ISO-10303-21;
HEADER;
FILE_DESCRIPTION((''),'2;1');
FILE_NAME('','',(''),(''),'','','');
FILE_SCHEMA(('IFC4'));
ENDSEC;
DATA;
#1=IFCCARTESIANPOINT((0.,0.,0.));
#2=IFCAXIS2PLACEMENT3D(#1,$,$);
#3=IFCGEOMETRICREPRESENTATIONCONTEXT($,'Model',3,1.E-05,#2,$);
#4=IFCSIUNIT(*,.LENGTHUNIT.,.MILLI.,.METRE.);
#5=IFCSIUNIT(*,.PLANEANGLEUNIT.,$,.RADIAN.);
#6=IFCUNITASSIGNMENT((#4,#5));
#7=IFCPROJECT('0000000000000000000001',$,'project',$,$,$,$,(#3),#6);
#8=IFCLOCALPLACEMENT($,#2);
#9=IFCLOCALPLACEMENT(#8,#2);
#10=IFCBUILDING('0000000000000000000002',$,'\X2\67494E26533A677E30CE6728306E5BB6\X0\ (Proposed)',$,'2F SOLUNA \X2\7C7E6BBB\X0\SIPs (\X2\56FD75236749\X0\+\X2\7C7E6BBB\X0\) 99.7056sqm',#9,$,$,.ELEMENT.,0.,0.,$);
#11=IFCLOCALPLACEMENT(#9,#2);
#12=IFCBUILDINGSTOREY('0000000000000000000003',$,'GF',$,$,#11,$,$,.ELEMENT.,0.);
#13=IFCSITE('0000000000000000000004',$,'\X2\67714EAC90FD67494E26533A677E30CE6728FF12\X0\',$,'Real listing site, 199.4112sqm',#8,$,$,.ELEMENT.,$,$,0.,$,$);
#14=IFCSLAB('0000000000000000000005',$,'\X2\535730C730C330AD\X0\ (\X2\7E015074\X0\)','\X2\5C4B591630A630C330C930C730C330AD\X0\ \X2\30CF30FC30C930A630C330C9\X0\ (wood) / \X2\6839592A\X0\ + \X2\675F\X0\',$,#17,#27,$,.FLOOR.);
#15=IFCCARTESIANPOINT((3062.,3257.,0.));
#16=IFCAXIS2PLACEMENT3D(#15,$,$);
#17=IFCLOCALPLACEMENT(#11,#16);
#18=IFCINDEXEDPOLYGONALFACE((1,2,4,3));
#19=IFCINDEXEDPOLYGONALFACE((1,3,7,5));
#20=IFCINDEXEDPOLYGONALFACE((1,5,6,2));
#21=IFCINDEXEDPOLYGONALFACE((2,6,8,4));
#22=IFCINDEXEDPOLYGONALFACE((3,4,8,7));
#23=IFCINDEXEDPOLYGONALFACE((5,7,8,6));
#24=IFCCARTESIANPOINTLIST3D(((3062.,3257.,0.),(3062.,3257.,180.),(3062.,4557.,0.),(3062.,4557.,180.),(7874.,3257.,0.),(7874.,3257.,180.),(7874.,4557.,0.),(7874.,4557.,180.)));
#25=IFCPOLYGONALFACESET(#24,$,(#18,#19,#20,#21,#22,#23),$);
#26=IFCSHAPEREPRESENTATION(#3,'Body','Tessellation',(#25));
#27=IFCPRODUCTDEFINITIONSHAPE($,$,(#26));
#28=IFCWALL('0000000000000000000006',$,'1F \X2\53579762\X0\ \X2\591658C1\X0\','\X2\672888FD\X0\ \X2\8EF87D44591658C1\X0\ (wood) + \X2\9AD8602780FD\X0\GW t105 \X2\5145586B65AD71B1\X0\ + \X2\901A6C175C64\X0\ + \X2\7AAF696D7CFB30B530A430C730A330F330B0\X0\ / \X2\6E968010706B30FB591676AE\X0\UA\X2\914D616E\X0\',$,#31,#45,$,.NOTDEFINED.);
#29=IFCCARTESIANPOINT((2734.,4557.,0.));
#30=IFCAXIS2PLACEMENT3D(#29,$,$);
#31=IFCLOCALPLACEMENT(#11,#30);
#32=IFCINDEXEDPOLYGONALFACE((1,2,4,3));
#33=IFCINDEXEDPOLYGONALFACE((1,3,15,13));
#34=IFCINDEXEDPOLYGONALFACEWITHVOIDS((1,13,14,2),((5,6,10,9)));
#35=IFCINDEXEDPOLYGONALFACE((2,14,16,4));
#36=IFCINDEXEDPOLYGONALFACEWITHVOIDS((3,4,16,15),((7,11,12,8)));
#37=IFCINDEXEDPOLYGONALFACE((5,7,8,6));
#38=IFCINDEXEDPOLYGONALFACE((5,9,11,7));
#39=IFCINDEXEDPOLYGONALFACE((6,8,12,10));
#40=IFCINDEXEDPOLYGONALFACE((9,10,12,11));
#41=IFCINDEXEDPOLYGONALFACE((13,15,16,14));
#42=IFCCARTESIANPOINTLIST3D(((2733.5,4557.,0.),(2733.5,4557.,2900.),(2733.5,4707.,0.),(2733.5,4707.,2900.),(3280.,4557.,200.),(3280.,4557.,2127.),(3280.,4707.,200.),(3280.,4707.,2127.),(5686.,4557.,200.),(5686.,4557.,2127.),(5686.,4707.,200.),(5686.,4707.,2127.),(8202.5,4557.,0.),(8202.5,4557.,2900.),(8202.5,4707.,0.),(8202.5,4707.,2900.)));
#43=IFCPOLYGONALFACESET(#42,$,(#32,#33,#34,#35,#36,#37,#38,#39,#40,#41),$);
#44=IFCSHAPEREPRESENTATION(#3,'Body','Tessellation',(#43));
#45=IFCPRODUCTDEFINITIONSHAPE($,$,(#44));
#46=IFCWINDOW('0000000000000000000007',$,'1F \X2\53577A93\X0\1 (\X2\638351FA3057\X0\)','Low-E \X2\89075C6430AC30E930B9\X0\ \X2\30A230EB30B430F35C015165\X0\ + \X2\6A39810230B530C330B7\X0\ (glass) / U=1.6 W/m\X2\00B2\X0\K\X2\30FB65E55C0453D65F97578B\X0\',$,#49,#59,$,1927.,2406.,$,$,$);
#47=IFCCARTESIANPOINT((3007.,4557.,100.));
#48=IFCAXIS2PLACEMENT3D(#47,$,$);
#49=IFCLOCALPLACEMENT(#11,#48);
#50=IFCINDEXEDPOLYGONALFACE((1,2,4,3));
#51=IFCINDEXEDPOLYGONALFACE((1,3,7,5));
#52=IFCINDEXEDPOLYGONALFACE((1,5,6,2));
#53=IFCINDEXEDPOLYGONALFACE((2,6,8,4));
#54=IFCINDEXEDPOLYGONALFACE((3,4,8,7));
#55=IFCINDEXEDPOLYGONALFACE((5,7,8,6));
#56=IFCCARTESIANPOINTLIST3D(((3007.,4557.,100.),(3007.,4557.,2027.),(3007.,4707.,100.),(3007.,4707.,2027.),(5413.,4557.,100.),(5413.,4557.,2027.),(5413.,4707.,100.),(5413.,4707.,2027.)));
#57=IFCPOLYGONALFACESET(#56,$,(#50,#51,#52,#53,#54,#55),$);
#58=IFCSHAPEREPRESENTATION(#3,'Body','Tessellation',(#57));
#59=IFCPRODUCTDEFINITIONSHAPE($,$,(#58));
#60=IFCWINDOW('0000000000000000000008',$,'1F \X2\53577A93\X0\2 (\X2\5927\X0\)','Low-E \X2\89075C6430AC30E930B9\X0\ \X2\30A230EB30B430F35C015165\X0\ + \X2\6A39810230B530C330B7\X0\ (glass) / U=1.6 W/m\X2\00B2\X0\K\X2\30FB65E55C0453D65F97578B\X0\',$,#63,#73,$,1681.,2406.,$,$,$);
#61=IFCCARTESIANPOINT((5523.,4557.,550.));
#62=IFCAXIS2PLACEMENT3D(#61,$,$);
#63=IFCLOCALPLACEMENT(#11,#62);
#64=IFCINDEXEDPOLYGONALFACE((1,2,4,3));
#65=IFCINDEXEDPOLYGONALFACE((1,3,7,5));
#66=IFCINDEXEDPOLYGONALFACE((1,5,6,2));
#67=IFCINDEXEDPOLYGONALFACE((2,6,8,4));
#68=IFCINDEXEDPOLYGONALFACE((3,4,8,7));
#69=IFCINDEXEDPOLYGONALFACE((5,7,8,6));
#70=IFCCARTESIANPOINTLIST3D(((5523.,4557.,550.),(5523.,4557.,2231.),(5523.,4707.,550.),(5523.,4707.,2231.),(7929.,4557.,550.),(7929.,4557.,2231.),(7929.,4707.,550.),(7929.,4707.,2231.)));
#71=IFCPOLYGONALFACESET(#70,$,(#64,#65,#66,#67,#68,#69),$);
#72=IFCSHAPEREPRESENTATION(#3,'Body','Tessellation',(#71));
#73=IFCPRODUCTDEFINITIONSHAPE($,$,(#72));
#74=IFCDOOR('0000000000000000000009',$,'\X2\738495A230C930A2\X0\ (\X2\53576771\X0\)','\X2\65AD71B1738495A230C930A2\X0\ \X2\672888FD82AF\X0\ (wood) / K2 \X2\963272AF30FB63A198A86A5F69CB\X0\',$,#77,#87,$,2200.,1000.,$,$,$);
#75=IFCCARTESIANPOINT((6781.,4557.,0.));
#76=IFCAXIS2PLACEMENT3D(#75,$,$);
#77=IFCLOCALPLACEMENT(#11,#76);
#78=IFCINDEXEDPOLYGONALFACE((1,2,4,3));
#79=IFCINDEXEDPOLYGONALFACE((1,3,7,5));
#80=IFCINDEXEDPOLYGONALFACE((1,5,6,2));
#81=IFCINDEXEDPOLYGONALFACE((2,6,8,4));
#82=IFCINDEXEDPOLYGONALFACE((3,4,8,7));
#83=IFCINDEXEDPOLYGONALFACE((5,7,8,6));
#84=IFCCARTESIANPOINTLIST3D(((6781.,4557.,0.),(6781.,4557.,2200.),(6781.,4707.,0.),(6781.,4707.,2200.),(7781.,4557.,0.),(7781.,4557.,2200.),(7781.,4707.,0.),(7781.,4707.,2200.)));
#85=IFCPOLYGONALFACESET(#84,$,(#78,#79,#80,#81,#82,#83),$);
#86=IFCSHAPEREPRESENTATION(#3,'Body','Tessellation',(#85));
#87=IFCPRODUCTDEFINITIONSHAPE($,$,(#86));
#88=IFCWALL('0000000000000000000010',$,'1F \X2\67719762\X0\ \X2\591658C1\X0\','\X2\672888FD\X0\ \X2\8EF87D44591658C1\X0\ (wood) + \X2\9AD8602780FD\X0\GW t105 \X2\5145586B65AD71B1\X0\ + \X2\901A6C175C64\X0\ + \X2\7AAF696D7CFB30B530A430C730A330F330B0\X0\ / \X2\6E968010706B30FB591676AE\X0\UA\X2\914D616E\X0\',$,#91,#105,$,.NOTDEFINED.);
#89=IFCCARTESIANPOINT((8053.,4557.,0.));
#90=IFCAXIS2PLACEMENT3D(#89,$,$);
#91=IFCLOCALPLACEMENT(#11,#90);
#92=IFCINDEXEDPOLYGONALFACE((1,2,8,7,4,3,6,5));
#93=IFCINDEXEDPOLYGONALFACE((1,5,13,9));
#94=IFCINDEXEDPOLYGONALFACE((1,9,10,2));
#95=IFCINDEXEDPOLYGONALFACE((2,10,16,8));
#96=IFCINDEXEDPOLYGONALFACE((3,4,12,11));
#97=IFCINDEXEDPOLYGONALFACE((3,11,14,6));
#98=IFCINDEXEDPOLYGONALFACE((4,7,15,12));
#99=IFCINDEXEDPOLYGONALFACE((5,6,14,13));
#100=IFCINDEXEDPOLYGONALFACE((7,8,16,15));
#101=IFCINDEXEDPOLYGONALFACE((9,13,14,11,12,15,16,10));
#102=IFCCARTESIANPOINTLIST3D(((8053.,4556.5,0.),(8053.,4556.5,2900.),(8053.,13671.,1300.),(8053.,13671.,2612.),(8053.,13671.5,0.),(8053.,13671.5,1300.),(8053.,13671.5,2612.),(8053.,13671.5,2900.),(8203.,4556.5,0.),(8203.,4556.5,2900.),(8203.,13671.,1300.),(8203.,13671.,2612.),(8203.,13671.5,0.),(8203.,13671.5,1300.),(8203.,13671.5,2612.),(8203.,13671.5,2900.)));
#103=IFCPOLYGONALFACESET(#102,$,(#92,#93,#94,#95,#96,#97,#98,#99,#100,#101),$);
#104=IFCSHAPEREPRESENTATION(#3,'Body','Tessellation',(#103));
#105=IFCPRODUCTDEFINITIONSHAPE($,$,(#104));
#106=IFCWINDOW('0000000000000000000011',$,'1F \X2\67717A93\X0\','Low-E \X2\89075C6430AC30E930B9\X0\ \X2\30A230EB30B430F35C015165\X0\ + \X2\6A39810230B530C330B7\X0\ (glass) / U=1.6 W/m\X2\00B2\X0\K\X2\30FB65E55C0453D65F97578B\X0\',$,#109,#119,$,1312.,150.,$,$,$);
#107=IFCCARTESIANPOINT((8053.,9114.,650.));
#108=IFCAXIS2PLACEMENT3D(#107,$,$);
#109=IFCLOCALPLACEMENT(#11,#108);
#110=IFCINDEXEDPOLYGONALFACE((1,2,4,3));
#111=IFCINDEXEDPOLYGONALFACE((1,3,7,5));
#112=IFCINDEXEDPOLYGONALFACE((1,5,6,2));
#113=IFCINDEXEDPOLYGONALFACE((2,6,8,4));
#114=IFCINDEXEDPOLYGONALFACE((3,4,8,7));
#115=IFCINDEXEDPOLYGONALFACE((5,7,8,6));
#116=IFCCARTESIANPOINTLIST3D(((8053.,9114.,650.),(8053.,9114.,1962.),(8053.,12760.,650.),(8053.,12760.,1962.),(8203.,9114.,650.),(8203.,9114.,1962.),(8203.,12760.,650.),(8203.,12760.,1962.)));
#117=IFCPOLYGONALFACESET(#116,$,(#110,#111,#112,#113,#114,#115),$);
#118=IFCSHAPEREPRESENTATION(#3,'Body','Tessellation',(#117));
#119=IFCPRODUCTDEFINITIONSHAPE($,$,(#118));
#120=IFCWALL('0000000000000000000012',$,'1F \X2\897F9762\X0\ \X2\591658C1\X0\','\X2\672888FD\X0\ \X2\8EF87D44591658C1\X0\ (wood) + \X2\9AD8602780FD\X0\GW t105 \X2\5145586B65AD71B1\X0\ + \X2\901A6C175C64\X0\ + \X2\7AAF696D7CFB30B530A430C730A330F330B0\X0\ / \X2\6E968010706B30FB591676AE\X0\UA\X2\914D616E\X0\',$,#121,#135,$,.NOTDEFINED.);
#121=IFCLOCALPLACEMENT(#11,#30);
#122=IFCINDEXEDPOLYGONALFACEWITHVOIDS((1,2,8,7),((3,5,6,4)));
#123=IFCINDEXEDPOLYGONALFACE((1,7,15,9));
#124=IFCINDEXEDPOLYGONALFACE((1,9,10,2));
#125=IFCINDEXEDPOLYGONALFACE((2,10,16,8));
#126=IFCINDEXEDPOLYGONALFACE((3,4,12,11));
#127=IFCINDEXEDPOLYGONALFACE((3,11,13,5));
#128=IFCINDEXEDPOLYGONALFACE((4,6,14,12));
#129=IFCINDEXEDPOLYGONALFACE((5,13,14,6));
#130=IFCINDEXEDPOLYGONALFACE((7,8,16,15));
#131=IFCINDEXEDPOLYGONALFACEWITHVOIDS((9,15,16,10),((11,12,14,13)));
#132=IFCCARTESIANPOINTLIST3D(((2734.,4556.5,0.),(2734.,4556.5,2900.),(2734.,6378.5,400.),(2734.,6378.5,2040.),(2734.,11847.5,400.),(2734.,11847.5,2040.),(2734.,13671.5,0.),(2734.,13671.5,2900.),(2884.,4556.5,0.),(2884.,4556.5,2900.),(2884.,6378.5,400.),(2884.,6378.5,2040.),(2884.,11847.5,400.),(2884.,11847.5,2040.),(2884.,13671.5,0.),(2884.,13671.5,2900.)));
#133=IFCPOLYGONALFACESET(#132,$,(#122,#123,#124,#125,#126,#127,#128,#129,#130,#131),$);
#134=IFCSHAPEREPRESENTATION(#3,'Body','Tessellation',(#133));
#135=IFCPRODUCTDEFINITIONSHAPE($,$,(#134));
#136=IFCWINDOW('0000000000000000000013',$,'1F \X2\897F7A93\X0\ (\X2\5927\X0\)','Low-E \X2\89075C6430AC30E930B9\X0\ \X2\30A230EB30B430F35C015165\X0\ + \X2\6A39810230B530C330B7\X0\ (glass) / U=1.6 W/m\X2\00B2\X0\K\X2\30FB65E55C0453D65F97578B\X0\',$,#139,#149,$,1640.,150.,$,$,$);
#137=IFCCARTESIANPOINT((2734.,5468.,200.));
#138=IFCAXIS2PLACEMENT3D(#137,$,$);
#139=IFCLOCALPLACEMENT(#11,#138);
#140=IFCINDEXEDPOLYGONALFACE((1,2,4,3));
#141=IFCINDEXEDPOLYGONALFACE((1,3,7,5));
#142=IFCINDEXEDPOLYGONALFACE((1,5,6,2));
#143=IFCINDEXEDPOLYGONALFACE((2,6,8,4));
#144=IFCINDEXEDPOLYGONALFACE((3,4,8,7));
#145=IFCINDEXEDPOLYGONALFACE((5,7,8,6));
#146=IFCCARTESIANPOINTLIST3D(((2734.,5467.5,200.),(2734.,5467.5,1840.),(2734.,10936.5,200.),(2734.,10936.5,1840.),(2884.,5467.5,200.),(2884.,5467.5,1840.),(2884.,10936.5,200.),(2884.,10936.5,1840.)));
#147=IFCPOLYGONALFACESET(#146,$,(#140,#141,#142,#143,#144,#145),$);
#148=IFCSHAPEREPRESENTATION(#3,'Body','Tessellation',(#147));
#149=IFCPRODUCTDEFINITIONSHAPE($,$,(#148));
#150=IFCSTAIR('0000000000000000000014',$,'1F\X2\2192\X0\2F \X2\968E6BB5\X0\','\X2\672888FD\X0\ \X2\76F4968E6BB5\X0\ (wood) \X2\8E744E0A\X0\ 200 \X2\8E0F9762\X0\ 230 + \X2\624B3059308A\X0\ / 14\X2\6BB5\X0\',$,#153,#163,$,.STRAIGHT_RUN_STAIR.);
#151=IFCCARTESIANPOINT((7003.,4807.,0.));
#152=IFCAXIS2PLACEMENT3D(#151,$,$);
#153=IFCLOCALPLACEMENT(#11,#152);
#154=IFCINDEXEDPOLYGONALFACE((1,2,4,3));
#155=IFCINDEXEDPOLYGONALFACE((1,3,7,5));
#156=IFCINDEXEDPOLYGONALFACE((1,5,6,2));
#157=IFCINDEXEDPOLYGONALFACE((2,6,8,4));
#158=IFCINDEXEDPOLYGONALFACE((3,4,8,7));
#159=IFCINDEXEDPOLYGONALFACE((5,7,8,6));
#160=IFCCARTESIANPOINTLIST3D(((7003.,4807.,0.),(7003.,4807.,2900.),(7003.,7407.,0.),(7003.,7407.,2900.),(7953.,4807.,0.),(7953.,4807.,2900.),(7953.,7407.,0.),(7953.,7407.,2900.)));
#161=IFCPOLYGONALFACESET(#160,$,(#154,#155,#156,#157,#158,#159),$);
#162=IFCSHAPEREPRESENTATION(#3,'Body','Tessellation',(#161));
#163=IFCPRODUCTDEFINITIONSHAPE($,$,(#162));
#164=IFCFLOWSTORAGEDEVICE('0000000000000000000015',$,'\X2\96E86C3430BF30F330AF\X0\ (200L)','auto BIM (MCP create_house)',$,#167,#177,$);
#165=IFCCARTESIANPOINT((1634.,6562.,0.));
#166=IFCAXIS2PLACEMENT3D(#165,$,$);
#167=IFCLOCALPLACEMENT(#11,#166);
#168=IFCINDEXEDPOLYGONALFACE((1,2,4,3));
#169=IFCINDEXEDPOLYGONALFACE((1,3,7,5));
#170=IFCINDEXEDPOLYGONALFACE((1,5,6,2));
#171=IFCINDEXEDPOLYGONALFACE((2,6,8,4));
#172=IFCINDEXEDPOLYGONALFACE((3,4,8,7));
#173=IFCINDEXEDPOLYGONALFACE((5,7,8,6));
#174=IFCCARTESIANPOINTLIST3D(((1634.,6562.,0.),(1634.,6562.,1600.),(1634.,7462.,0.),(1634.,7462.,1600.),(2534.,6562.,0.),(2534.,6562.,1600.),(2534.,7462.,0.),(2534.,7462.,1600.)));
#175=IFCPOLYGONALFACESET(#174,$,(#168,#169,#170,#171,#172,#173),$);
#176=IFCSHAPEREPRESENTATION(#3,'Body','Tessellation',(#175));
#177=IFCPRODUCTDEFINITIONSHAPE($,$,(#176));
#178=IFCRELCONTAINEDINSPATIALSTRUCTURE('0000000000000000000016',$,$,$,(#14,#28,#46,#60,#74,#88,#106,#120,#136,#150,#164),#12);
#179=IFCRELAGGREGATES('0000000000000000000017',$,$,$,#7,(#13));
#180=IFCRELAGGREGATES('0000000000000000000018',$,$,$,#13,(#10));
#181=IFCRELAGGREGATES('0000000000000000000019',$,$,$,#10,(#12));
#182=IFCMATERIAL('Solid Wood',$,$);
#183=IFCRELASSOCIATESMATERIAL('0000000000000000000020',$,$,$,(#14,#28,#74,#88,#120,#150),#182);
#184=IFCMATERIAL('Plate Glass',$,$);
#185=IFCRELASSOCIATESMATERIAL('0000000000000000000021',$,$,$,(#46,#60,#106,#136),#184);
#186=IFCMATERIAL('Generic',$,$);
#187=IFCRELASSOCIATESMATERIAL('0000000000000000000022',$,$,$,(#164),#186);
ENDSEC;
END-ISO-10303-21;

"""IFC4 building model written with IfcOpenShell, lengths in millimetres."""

from ifc_helpers import new_model, si_unit, frame, frame_2d, origin, place, context, project, spatial, rectangle, extrude, material, element, fill, save


model = new_model("IFC4")

# Units and contexts
model_context = context("Model", 3, precision=1e-05, world=origin())
ifc_project = project(units=[si_unit("LENGTHUNIT", "METRE", prefix="MILLI"), si_unit("PLANEANGLEUNIT", "RADIAN")], contexts=[model_context])

# Site, building, storey
site_placement = place(None, origin())
site = spatial("IfcSite", under=ifc_project, at=site_placement, Name="東京都杉並区松ノ木２", ObjectType="Real listing site, 199.4112sqm", CompositionType="ELEMENT", RefElevation=0.0)
building_placement = place(site_placement, origin())
building = spatial("IfcBuilding", under=site, at=building_placement, Name="杉並区松ノ木の家 (Proposed)", ObjectType="2F SOLUNA 籾殻SIPs (国産杉+籾殻) 99.7056sqm", CompositionType="ELEMENT", ElevationOfRefHeight=0.0, ElevationOfTerrain=0.0)
storey_placement = place(building_placement, origin())
storey = spatial("IfcBuildingStorey", under=building, at=storey_placement, Name="GF", CompositionType="ELEMENT", Elevation=0.0)

# Slab
ifc_material_1 = material(Name="Solid Wood")
slab_1_placement = place(storey_placement, frame((3062.0, 3257.0, 0.0)))
element("IfcSlab", 1, at=slab_1_placement, inside=storey, material=ifc_material_1, Name="南デッキ (縁側)", Description="屋外ウッドデッキ ハードウッド (wood) / 根太 + 束", PredefinedType="FLOOR", context=model_context, shape_type="SweptSolid", body=[
    extrude(rectangle(XDim=4812.0, YDim=1300.0, at=frame_2d((2406.0, 650.0))), frame((3062.0, 3257.0, 0.0)), (0.0, 0.0, 1.0), 180.0),
])

# Wall, openings, windows, door
wall_1_placement = place(storey_placement, frame((2734.0, 4557.0, 0.0)))
wall_1 = element("IfcWall", 2, at=wall_1_placement, inside=storey, material=ifc_material_1, Name="1F 南面 外壁", Description="木製 軸組外壁 (wood) + 高性能GW t105 充填断熱 + 通気層 + 窯業系サイディング / 準耐火・外皮UA配慮", PredefinedType="NOTDEFINED", context=model_context, shape_type="SweptSolid", body=[
    extrude(rectangle(XDim=5469.0, YDim=150.0, at=frame_2d((2734.0, 75.0))), frame((2734.0, 4557.0, 0.0)), (0.0, 0.0, 1.0), 2900.0),
])
opening_1_placement = place(storey_placement, frame((3007.0, 4557.0, 100.0)))
opening_1 = element("IfcOpeningElement", 3, at=opening_1_placement, cuts=wall_1, PredefinedType="NOTDEFINED", context=model_context, shape_type="SweptSolid", body=[
    extrude(rectangle(XDim=2406.0, YDim=150.0, at=frame_2d((1203.0, 75.0))), frame((3007.0, 4557.0, 100.0)), (0.0, 0.0, 1.0), 1927.0),
])
opening_2_placement = place(storey_placement, frame((5523.0, 4557.0, 550.0)))
opening_2 = element("IfcOpeningElement", 4, at=opening_2_placement, cuts=wall_1, PredefinedType="NOTDEFINED", context=model_context, shape_type="SweptSolid", body=[
    extrude(rectangle(XDim=2406.0, YDim=150.0, at=frame_2d((1203.0, 75.0))), frame((5523.0, 4557.0, 550.0)), (0.0, 0.0, 1.0), 1681.0),
])
opening_3_placement = place(storey_placement, frame((6781.0, 4557.0, 0.0)))
opening_3 = element("IfcOpeningElement", 5, at=opening_3_placement, cuts=wall_1, PredefinedType="NOTDEFINED", context=model_context, shape_type="SweptSolid", body=[
    extrude(rectangle(XDim=1000.0, YDim=150.0, at=frame_2d((500.0, 75.0))), frame((6781.0, 4557.0, 0.0)), (0.0, 0.0, 1.0), 2200.0),
])
ifc_material_2 = material(Name="Plate Glass")
window_1_placement = place(storey_placement, frame((3007.0, 4557.0, 100.0)))
window_1 = element("IfcWindow", 6, at=window_1_placement, inside=storey, material=ifc_material_2, Name="1F 南窓1 (掃出し)", Description="Low-E 複層ガラス アルゴン封入 + 樹脂サッシ (glass) / U=1.6 W/m²K・日射取得型", OverallHeight=1927.0, OverallWidth=2406.0, context=model_context, shape_type="SweptSolid", body=[
    extrude(rectangle(XDim=2406.0, YDim=150.0, at=frame_2d((1203.0, 75.0))), frame((3007.0, 4557.0, 100.0)), (0.0, 0.0, 1.0), 1927.0),
])
fill(opening_1, window_1)
window_2_placement = place(storey_placement, frame((5523.0, 4557.0, 550.0)))
window_2 = element("IfcWindow", 7, at=window_2_placement, inside=storey, material=ifc_material_2, Name="1F 南窓2 (大)", Description="Low-E 複層ガラス アルゴン封入 + 樹脂サッシ (glass) / U=1.6 W/m²K・日射取得型", OverallHeight=1681.0, OverallWidth=2406.0, context=model_context, shape_type="SweptSolid", body=[
    extrude(rectangle(XDim=2406.0, YDim=150.0, at=frame_2d((1203.0, 75.0))), frame((5523.0, 4557.0, 550.0)), (0.0, 0.0, 1.0), 1681.0),
])
fill(opening_2, window_2)
door_placement = place(storey_placement, frame((6781.0, 4557.0, 0.0)))
door = element("IfcDoor", 8, at=door_placement, inside=storey, material=ifc_material_1, Name="玄関ドア (南東)", Description="断熱玄関ドア 木製芯 (wood) / K2 防犯・採風機構", OverallHeight=2200.0, OverallWidth=1000.0, context=model_context, shape_type="SweptSolid", body=[
    extrude(rectangle(XDim=1000.0, YDim=150.0, at=frame_2d((500.0, 75.0))), frame((6781.0, 4557.0, 0.0)), (0.0, 0.0, 1.0), 2200.0),
])
fill(opening_3, door)

# Walls, openings, windows
wall_2_placement = place(storey_placement, frame((8053.0, 4557.0, 0.0)))
wall_2 = element("IfcWall", 9, at=wall_2_placement, inside=storey, material=ifc_material_1, Name="1F 東面 外壁", Description="木製 軸組外壁 (wood) + 高性能GW t105 充填断熱 + 通気層 + 窯業系サイディング / 準耐火・外皮UA配慮", PredefinedType="NOTDEFINED", context=model_context, shape_type="SweptSolid", body=[
    extrude(rectangle(XDim=150.0, YDim=9115.0, at=frame_2d((75.0, 4557.0))), frame((8053.0, 4557.0, 0.0)), (0.0, 0.0, 1.0), 2900.0),
])
opening_4_placement = place(storey_placement, frame((8053.0, 9114.0, 650.0)))
opening_4 = element("IfcOpeningElement", 10, at=opening_4_placement, cuts=wall_2, PredefinedType="NOTDEFINED", context=model_context, shape_type="SweptSolid", body=[
    extrude(rectangle(XDim=150.0, YDim=3646.0, at=frame_2d((75.0, 1823.0))), frame((8053.0, 9114.0, 650.0)), (0.0, 0.0, 1.0), 1312.0),
])
window_3_placement = place(storey_placement, frame((8053.0, 9114.0, 650.0)))
window_3 = element("IfcWindow", 11, at=window_3_placement, inside=storey, material=ifc_material_2, Name="1F 東窓", Description="Low-E 複層ガラス アルゴン封入 + 樹脂サッシ (glass) / U=1.6 W/m²K・日射取得型", OverallHeight=1312.0, OverallWidth=150.0, context=model_context, shape_type="SweptSolid", body=[
    extrude(rectangle(XDim=150.0, YDim=3646.0, at=frame_2d((75.0, 1823.0))), frame((8053.0, 9114.0, 650.0)), (0.0, 0.0, 1.0), 1312.0),
])
fill(opening_4, window_3)
wall_3_placement = place(storey_placement, frame((2734.0, 4557.0, 0.0)))
wall_3 = element("IfcWall", 12, at=wall_3_placement, inside=storey, material=ifc_material_1, Name="1F 西面 外壁", Description="木製 軸組外壁 (wood) + 高性能GW t105 充填断熱 + 通気層 + 窯業系サイディング / 準耐火・外皮UA配慮", PredefinedType="NOTDEFINED", context=model_context, shape_type="SweptSolid", body=[
    extrude(rectangle(XDim=150.0, YDim=9115.0, at=frame_2d((75.0, 4557.0))), frame((2734.0, 4557.0, 0.0)), (0.0, 0.0, 1.0), 2900.0),
])
opening_5_placement = place(storey_placement, frame((2734.0, 5468.0, 200.0)))
opening_5 = element("IfcOpeningElement", 13, at=opening_5_placement, cuts=wall_3, PredefinedType="NOTDEFINED", context=model_context, shape_type="SweptSolid", body=[
    extrude(rectangle(XDim=150.0, YDim=5469.0, at=frame_2d((75.0, 2734.0))), frame((2734.0, 5468.0, 200.0)), (0.0, 0.0, 1.0), 1640.0),
])
window_4_placement = place(storey_placement, frame((2734.0, 5468.0, 200.0)))
window_4 = element("IfcWindow", 14, at=window_4_placement, inside=storey, material=ifc_material_2, Name="1F 西窓 (大)", Description="Low-E 複層ガラス アルゴン封入 + 樹脂サッシ (glass) / U=1.6 W/m²K・日射取得型", OverallHeight=1640.0, OverallWidth=150.0, context=model_context, shape_type="SweptSolid", body=[
    extrude(rectangle(XDim=150.0, YDim=5469.0, at=frame_2d((75.0, 2734.0))), frame((2734.0, 5468.0, 200.0)), (0.0, 0.0, 1.0), 1640.0),
])
fill(opening_5, window_4)

# Stair
stair_placement = place(storey_placement, frame((7003.0, 4807.0, 0.0)))
element("IfcStair", 15, at=stair_placement, inside=storey, material=ifc_material_1, Name="1F→2F 階段", Description="木製 直階段 (wood) 蹴上 200 踏面 230 + 手すり / 14段", PredefinedType="STRAIGHT_RUN_STAIR", context=model_context, shape_type="SweptSolid", body=[
    extrude(rectangle(XDim=950.0, YDim=2600.0, at=frame_2d((475.0, 1300.0))), frame((7003.0, 4807.0, 0.0)), (0.0, 0.0, 1.0), 2900.0),
])

# Shared definitions
ifc_material_3 = material(Name="Generic")

# Flow storage device
flow_storage_device_placement = place(storey_placement, frame((1634.0, 6562.0, 0.0)))
element("IfcFlowStorageDevice", 16, at=flow_storage_device_placement, inside=storey, material=ifc_material_3, Name="雨水タンク (200L)", Description="auto BIM (MCP create_house)", context=model_context, shape_type="SweptSolid", body=[
    extrude(rectangle(XDim=900.0, YDim=900.0, at=frame_2d((450.0, 450.0))), frame((1634.0, 6562.0, 0.0)), (0.0, 0.0, 1.0), 1600.0),
])

save(model, "model.ifc")
